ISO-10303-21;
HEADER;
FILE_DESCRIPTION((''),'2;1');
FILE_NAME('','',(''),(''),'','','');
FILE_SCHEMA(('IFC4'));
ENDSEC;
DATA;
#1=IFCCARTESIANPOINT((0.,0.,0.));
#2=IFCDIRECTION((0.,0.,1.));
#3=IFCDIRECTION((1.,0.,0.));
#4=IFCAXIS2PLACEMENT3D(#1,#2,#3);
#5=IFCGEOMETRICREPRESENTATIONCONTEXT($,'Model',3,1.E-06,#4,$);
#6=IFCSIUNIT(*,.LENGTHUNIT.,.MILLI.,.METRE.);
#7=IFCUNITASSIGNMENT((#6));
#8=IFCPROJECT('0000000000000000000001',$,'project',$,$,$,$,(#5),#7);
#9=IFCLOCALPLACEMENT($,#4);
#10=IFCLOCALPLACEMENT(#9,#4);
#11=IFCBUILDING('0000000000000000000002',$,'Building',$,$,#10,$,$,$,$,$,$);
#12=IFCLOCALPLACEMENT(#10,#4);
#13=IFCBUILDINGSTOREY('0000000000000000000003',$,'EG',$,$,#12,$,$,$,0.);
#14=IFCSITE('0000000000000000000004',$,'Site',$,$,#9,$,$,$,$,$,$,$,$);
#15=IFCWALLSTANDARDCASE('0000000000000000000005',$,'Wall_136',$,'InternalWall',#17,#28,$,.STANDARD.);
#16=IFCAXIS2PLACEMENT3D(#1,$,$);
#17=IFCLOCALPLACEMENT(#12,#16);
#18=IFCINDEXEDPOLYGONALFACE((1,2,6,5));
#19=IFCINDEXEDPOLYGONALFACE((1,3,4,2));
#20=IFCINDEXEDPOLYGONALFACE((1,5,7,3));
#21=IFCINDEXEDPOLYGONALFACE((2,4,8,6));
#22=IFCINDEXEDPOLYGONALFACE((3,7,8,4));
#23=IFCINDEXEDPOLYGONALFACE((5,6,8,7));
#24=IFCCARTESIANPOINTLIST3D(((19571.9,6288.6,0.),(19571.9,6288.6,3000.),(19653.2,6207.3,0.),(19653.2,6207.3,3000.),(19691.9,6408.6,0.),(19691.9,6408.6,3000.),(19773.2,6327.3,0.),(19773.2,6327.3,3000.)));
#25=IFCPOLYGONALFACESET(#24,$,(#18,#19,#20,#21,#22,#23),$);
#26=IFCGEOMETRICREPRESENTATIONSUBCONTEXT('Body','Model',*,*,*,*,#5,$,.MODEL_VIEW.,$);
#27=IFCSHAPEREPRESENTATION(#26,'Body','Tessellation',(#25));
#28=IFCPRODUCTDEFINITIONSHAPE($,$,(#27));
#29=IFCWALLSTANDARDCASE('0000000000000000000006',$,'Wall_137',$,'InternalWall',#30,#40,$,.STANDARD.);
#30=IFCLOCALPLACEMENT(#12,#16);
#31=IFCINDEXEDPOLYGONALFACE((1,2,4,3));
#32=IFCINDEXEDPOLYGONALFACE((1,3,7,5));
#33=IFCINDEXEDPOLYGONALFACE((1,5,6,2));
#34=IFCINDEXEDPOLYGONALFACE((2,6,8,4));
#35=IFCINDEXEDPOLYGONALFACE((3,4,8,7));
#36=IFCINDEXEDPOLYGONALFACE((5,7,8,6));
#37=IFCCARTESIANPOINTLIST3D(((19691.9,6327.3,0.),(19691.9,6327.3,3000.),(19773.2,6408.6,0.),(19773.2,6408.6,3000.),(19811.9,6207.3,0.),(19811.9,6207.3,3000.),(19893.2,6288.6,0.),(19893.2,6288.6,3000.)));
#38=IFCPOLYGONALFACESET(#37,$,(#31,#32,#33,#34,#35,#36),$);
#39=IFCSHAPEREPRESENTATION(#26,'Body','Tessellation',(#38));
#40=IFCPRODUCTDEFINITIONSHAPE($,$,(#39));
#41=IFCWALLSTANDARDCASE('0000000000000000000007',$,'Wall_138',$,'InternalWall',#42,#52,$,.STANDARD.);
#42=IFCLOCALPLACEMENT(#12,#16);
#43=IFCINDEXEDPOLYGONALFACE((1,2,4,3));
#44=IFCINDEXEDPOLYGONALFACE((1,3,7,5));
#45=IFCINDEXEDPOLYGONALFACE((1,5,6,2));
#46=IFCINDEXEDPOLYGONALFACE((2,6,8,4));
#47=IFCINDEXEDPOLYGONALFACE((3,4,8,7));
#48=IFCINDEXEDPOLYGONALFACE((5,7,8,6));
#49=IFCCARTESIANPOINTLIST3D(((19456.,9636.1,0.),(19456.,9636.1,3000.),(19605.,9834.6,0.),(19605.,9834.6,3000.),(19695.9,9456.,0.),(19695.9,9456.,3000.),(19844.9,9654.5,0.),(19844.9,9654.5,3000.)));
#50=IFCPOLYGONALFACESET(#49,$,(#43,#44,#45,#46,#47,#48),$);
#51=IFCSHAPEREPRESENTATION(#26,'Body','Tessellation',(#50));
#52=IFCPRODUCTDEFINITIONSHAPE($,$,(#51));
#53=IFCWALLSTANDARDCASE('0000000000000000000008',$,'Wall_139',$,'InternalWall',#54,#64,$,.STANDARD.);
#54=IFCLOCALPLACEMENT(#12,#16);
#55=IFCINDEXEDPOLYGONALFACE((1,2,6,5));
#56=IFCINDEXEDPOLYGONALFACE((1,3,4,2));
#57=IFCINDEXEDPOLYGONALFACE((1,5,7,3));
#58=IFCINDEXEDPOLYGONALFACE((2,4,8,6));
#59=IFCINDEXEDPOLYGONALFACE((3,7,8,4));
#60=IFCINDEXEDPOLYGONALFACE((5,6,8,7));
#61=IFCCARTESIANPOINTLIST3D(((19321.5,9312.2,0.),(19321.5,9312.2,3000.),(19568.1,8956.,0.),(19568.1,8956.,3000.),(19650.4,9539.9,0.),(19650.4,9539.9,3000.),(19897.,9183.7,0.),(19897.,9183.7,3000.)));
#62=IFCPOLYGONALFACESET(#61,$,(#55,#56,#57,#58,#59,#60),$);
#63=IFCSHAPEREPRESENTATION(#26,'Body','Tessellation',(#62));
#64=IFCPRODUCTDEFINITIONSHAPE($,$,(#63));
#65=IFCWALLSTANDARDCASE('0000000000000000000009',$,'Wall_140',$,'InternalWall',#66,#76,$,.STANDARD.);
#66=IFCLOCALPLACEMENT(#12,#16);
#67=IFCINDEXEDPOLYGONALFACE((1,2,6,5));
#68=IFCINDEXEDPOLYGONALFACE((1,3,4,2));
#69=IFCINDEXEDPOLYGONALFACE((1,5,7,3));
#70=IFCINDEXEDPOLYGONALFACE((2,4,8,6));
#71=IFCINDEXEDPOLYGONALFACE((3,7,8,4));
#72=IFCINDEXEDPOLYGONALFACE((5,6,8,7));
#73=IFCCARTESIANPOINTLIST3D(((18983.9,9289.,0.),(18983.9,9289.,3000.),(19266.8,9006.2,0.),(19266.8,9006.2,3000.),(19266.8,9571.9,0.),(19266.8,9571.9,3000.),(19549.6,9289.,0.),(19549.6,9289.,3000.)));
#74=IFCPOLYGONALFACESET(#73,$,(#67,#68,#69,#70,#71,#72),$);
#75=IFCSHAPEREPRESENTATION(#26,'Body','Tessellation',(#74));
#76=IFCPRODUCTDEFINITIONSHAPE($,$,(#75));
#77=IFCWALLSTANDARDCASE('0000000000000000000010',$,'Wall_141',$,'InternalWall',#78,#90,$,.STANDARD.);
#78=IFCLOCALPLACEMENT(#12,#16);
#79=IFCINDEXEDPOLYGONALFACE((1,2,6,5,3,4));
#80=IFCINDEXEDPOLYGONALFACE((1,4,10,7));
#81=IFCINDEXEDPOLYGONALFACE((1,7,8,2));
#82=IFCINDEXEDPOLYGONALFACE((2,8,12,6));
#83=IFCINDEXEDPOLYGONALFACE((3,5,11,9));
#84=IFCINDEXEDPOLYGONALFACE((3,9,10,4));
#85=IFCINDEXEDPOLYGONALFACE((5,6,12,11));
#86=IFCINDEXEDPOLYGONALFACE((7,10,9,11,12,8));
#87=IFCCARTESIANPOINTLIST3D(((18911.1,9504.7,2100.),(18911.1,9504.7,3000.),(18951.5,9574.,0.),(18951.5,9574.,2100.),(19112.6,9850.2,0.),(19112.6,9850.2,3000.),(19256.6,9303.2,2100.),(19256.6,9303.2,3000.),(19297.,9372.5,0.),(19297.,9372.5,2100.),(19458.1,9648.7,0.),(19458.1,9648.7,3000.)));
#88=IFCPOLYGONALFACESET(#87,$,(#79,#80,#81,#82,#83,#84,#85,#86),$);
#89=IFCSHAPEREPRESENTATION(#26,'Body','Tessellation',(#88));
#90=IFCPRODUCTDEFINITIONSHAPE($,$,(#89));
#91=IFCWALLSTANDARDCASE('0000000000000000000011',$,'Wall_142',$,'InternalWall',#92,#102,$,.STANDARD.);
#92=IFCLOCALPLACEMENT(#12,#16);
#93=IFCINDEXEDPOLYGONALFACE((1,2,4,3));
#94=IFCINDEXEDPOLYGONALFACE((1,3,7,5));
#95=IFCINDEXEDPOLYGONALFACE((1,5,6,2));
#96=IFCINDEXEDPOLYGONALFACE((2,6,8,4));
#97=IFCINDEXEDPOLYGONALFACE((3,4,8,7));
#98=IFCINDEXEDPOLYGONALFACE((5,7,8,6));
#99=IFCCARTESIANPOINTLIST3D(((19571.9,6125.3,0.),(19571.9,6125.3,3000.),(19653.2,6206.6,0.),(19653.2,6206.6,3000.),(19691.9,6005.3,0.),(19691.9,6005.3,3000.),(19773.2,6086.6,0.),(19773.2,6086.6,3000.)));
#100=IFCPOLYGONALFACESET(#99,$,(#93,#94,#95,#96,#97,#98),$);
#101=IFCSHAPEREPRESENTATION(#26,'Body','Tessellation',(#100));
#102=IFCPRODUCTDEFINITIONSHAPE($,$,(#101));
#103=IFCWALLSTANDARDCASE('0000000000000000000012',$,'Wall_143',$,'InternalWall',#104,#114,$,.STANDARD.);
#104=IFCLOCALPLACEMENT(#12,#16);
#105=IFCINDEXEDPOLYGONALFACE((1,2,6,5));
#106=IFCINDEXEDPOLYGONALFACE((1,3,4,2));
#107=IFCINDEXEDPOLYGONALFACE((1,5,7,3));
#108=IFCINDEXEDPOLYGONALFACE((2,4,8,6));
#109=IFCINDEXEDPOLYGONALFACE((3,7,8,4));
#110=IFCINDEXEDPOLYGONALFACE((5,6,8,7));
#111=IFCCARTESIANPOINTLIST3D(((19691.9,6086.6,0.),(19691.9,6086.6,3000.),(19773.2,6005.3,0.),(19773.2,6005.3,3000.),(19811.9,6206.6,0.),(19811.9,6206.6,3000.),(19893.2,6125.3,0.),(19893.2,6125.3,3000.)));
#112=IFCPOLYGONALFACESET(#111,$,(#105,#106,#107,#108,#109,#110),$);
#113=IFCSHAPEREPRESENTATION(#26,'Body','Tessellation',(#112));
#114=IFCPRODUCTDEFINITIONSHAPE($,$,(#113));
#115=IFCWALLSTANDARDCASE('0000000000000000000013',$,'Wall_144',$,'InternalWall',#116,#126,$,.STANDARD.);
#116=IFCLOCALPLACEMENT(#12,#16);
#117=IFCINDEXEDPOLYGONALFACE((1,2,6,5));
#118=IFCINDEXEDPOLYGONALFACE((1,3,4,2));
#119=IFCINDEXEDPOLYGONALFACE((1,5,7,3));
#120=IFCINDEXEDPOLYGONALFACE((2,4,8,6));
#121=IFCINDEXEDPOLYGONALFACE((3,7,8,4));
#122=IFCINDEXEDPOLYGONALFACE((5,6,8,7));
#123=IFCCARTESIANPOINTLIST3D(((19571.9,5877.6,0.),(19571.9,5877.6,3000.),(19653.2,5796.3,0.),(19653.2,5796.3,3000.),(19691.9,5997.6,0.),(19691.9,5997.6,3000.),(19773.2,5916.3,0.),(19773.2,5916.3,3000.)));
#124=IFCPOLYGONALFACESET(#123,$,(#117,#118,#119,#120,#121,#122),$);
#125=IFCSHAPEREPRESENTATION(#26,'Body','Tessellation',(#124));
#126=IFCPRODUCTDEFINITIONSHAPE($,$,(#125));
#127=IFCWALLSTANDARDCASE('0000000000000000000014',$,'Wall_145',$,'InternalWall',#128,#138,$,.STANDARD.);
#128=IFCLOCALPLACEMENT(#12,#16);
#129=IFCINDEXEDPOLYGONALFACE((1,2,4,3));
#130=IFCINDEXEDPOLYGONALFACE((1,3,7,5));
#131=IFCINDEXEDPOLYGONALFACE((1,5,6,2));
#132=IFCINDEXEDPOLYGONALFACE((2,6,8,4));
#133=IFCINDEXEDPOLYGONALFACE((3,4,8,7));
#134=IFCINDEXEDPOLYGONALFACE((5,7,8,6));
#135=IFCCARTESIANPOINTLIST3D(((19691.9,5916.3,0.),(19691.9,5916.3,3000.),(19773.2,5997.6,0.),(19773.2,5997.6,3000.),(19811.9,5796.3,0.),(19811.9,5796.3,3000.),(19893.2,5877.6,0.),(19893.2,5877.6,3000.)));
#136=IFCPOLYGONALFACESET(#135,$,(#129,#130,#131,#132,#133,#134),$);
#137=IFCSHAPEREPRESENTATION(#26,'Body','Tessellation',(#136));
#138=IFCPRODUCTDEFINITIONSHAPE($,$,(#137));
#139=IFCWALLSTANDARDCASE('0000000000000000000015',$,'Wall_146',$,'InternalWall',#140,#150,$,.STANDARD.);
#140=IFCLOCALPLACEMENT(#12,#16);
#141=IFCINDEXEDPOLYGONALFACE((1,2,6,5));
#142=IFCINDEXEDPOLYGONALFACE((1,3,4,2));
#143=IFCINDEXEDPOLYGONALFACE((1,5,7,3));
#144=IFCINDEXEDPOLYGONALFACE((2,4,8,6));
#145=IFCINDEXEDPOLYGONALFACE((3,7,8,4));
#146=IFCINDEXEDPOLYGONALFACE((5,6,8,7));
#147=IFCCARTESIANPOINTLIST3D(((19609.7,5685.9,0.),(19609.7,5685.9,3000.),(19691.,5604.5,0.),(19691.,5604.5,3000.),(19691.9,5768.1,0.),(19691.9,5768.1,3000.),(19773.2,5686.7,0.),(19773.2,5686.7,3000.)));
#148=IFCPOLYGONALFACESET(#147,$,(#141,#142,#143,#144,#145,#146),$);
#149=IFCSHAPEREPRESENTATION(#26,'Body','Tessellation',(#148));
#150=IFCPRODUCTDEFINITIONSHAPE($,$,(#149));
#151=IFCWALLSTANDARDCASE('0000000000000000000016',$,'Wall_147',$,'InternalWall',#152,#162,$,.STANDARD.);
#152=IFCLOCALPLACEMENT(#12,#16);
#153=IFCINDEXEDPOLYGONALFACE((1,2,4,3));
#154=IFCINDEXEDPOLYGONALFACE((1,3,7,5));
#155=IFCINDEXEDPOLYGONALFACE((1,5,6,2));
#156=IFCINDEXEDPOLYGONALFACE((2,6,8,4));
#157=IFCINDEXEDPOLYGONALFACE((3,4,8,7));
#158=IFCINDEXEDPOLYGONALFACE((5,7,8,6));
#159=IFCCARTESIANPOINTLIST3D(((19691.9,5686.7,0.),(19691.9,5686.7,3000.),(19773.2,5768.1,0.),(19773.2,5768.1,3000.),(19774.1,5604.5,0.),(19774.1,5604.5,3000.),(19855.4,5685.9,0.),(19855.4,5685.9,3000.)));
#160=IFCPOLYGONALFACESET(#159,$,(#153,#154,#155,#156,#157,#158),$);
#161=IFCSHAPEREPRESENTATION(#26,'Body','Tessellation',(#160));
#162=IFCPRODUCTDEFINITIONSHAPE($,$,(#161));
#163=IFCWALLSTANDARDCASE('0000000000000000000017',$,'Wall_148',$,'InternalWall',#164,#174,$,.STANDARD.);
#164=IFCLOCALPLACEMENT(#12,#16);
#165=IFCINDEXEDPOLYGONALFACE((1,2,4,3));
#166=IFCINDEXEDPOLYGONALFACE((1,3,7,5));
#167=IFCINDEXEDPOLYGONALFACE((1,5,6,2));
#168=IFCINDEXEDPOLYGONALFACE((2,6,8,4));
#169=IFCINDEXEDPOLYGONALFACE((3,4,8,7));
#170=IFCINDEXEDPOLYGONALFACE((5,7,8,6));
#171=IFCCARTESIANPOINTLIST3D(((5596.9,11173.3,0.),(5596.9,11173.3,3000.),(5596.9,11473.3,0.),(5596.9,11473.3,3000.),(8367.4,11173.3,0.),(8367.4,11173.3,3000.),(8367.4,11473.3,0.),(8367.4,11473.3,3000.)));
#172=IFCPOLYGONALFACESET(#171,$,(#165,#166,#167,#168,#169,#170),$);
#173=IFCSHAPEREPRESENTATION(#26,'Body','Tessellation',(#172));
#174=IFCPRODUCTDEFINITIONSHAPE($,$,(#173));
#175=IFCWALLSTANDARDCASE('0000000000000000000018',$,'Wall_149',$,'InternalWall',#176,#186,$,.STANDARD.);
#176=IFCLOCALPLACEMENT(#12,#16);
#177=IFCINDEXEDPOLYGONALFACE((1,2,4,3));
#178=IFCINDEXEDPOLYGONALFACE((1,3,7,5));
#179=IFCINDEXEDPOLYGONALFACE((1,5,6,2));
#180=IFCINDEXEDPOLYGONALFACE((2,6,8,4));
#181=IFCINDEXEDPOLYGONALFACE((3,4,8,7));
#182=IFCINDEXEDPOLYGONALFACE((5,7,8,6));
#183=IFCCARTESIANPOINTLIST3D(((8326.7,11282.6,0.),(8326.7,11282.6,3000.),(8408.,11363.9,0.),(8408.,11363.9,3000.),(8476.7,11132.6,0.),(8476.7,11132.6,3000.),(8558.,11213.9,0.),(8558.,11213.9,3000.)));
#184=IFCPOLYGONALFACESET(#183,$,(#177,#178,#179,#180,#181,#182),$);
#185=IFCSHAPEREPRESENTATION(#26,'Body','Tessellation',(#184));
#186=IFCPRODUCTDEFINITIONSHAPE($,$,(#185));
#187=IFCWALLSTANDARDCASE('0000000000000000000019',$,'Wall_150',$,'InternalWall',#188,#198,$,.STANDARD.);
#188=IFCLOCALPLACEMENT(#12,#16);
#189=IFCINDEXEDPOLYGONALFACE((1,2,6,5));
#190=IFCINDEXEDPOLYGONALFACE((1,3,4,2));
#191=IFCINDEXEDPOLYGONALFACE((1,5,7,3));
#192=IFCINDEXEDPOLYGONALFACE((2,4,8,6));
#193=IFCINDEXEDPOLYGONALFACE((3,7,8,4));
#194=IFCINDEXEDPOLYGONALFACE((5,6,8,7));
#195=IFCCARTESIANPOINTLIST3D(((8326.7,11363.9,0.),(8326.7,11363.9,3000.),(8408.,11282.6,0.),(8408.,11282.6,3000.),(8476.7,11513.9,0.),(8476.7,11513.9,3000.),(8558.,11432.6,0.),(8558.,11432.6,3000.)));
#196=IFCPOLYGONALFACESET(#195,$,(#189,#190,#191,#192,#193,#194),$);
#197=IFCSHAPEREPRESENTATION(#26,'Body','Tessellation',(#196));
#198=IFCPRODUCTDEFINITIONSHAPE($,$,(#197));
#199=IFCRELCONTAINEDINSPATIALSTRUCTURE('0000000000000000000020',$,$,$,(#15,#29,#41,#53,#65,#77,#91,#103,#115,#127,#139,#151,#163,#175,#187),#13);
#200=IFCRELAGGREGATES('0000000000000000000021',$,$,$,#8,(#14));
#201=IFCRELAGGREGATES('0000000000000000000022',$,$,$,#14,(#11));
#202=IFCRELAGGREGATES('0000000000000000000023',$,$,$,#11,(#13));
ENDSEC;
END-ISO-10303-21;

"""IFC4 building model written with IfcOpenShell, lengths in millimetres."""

from ifc_helpers import new_model, si_unit, frame, origin_with_axes, place, context, subcontext, project, spatial, rectangle, extrude, element, save


model = new_model("IFC4")

# Units and contexts
model_context = context("Model", 3, precision=1e-06, world=origin_with_axes())
body_context = subcontext(model_context, "Body", "Model", "MODEL_VIEW")
ifc_project = project(units=[si_unit("LENGTHUNIT", "METRE", prefix="MILLI")], contexts=[model_context])

# Site, building, storey
site_placement = place(None, origin_with_axes())
site = spatial("IfcSite", under=ifc_project, at=site_placement, Name="Site")
building_placement = place(site_placement, origin_with_axes())
building = spatial("IfcBuilding", under=site, at=building_placement, Name="Building")
storey_placement = place(building_placement, origin_with_axes())
storey = spatial("IfcBuildingStorey", under=building, at=storey_placement, Name="EG", Elevation=0.0)

# Walls
wall_1_placement = place(storey_placement, origin_with_axes())
element("IfcWallStandardCase", 1, at=wall_1_placement, inside=storey, Name="Wall_136", ObjectType="InternalWall", PredefinedType="STANDARD", context=body_context, shape_type="SweptSolid", body=[
    extrude(rectangle(XDim=169.7, YDim=115.0), frame((19672.5, 6307.9, 0.0), z_axis=(0.0, 0.0, 1.0), x_axis=(-0.707107, -0.707107, 0.0)), (0.0, 0.0, 1.0), 3000.0),
])
wall_2_placement = place(storey_placement, origin_with_axes())
element("IfcWallStandardCase", 2, at=wall_2_placement, inside=storey, Name="Wall_137", ObjectType="InternalWall", PredefinedType="STANDARD", context=body_context, shape_type="SweptSolid", body=[
    extrude(rectangle(XDim=169.7, YDim=115.0), frame((19792.5, 6307.9, 0.0), z_axis=(0.0, 0.0, 1.0), x_axis=(0.707107, -0.707107, 0.0)), (0.0, 0.0, 1.0), 3000.0),
])
wall_3_placement = place(storey_placement, origin_with_axes())
element("IfcWallStandardCase", 3, at=wall_3_placement, inside=storey, Name="Wall_138", ObjectType="InternalWall", PredefinedType="STANDARD", context=body_context, shape_type="SweptSolid", body=[
    extrude(rectangle(XDim=248.2, YDim=300.0), frame((19650.5, 9645.3, 0.0), z_axis=(0.0, 0.0, 1.0), x_axis=(-0.600322, -0.799758, 0.0)), (0.0, 0.0, 1.0), 3000.0),
])
wall_4_placement = place(storey_placement, origin_with_axes())
element("IfcWallStandardCase", 4, at=wall_4_placement, inside=storey, Name="Wall_139", ObjectType="InternalWall", PredefinedType="STANDARD", context=body_context, shape_type="SweptSolid", body=[
    extrude(rectangle(XDim=433.2, YDim=400.0), frame((19609.2, 9247.9, 0.0), z_axis=(0.0, 0.0, 1.0), x_axis=(-0.56921, 0.822192, 0.0)), (0.0, 0.0, 1.0), 3000.0),
])
wall_5_placement = place(storey_placement, origin_with_axes())
element("IfcWallStandardCase", 5, at=wall_5_placement, inside=storey, Name="Wall_140", ObjectType="InternalWall", PredefinedType="STANDARD", context=body_context, shape_type="SweptSolid", body=[
    extrude(rectangle(XDim=400.0, YDim=400.0), frame((19266.8, 9289.0, 0.0), z_axis=(0.0, 0.0, 1.0), x_axis=(-0.707107, 0.707107, 0.0)), (0.0, 0.0, 1.0), 3000.0),
])

# Wall, opening
wall_6_placement = place(storey_placement, origin_with_axes())
wall_6 = element("IfcWallStandardCase", 6, at=wall_6_placement, inside=storey, Name="Wall_141", ObjectType="InternalWall", PredefinedType="STANDARD", context=body_context, shape_type="SweptSolid", body=[
    extrude(rectangle(XDim=400.0, YDim=400.0), frame((19184.6, 9576.7, 0.0), z_axis=(0.0, 0.0, 1.0), x_axis=(0.503871, 0.863779, 0.0)), (0.0, 0.0, 1.0), 3000.0),
])
opening_1_placement = place(wall_6_placement, origin_with_axes())
element("IfcOpeningElement", 7, at=opening_1_placement, inside=storey, cuts=wall_6, context=body_context, shape_type="SweptSolid", body=[
    extrude(rectangle(XDim=1051.2, YDim=400.0), frame((18859.4, 9019.2, 0.0), z_axis=(0.0, 0.0, 1.0), x_axis=(0.503871, 0.863779, 0.0)), (0.0, 0.0, 1.0), 2100.0),
])

# Walls
wall_7_placement = place(storey_placement, origin_with_axes())
element("IfcWallStandardCase", 8, at=wall_7_placement, inside=storey, Name="Wall_142", ObjectType="InternalWall", PredefinedType="STANDARD", context=body_context, shape_type="SweptSolid", body=[
    extrude(rectangle(XDim=169.7, YDim=115.0), frame((19672.5, 6106.0, 0.0), z_axis=(0.0, 0.0, 1.0), x_axis=(0.707107, -0.707107, 0.0)), (0.0, 0.0, 1.0), 3000.0),
])
wall_8_placement = place(storey_placement, origin_with_axes())
element("IfcWallStandardCase", 9, at=wall_8_placement, inside=storey, Name="Wall_143", ObjectType="InternalWall", PredefinedType="STANDARD", context=body_context, shape_type="SweptSolid", body=[
    extrude(rectangle(XDim=169.7, YDim=115.0), frame((19792.5, 6106.0, 0.0), z_axis=(0.0, 0.0, 1.0), x_axis=(0.707107, 0.707107, 0.0)), (0.0, 0.0, 1.0), 3000.0),
])
wall_9_placement = place(storey_placement, origin_with_axes())
element("IfcWallStandardCase", 10, at=wall_9_placement, inside=storey, Name="Wall_144", ObjectType="InternalWall", PredefinedType="STANDARD", context=body_context, shape_type="SweptSolid", body=[
    extrude(rectangle(XDim=169.7, YDim=115.0), frame((19672.5, 5897.0, 0.0), z_axis=(0.0, 0.0, 1.0), x_axis=(-0.707107, -0.707107, 0.0)), (0.0, 0.0, 1.0), 3000.0),
])
wall_10_placement = place(storey_placement, origin_with_axes())
element("IfcWallStandardCase", 11, at=wall_10_placement, inside=storey, Name="Wall_145", ObjectType="InternalWall", PredefinedType="STANDARD", context=body_context, shape_type="SweptSolid", body=[
    extrude(rectangle(XDim=169.7, YDim=115.0), frame((19792.5, 5897.0, 0.0), z_axis=(0.0, 0.0, 1.0), x_axis=(0.707107, -0.707107, 0.0)), (0.0, 0.0, 1.0), 3000.0),
])
wall_11_placement = place(storey_placement, origin_with_axes())
element("IfcWallStandardCase", 12, at=wall_11_placement, inside=storey, Name="Wall_146", ObjectType="InternalWall", PredefinedType="STANDARD", context=body_context, shape_type="SweptSolid", body=[
    extrude(rectangle(XDim=116.2, YDim=115.0), frame((19691.4, 5686.3, 0.0), z_axis=(0.0, 0.0, 1.0), x_axis=(0.707107, 0.707107, 0.0)), (0.0, 0.0, 1.0), 3000.0),
])
wall_12_placement = place(storey_placement, origin_with_axes())
element("IfcWallStandardCase", 13, at=wall_12_placement, inside=storey, Name="Wall_147", ObjectType="InternalWall", PredefinedType="STANDARD", context=body_context, shape_type="SweptSolid", body=[
    extrude(rectangle(XDim=116.2, YDim=115.0), frame((19773.6, 5686.3, 0.0), z_axis=(0.0, 0.0, 1.0), x_axis=(-0.707107, 0.707107, 0.0)), (0.0, 0.0, 1.0), 3000.0),
])
wall_13_placement = place(storey_placement, origin_with_axes())
element("IfcWallStandardCase", 14, at=wall_13_placement, inside=storey, Name="Wall_148", ObjectType="InternalWall", PredefinedType="STANDARD", context=body_context, shape_type="SweptSolid", body=[
    extrude(rectangle(XDim=2770.5, YDim=300.0), frame((6982.1, 11323.3, 0.0), z_axis=(0.0, 0.0, 1.0), x_axis=(-1.0, 0.0, 0.0)), (0.0, 0.0, 1.0), 3000.0),
])
wall_14_placement = place(storey_placement, origin_with_axes())
element("IfcWallStandardCase", 15, at=wall_14_placement, inside=storey, Name="Wall_149", ObjectType="InternalWall", PredefinedType="STANDARD", context=body_context, shape_type="SweptSolid", body=[
    extrude(rectangle(XDim=212.1, YDim=115.0), frame((8442.4, 11248.3, 0.0), z_axis=(0.0, 0.0, 1.0), x_axis=(0.707107, -0.707107, 0.0)), (0.0, 0.0, 1.0), 3000.0),
])
wall_15_placement = place(storey_placement, origin_with_axes())
element("IfcWallStandardCase", 16, at=wall_15_placement, inside=storey, Name="Wall_150", ObjectType="InternalWall", PredefinedType="STANDARD", context=body_context, shape_type="SweptSolid", body=[
    extrude(rectangle(XDim=212.1, YDim=115.0), frame((8442.4, 11398.3, 0.0), z_axis=(0.0, 0.0, 1.0), x_axis=(0.707107, 0.707107, 0.0)), (0.0, 0.0, 1.0), 3000.0),
])

save(model, "model.ifc")
